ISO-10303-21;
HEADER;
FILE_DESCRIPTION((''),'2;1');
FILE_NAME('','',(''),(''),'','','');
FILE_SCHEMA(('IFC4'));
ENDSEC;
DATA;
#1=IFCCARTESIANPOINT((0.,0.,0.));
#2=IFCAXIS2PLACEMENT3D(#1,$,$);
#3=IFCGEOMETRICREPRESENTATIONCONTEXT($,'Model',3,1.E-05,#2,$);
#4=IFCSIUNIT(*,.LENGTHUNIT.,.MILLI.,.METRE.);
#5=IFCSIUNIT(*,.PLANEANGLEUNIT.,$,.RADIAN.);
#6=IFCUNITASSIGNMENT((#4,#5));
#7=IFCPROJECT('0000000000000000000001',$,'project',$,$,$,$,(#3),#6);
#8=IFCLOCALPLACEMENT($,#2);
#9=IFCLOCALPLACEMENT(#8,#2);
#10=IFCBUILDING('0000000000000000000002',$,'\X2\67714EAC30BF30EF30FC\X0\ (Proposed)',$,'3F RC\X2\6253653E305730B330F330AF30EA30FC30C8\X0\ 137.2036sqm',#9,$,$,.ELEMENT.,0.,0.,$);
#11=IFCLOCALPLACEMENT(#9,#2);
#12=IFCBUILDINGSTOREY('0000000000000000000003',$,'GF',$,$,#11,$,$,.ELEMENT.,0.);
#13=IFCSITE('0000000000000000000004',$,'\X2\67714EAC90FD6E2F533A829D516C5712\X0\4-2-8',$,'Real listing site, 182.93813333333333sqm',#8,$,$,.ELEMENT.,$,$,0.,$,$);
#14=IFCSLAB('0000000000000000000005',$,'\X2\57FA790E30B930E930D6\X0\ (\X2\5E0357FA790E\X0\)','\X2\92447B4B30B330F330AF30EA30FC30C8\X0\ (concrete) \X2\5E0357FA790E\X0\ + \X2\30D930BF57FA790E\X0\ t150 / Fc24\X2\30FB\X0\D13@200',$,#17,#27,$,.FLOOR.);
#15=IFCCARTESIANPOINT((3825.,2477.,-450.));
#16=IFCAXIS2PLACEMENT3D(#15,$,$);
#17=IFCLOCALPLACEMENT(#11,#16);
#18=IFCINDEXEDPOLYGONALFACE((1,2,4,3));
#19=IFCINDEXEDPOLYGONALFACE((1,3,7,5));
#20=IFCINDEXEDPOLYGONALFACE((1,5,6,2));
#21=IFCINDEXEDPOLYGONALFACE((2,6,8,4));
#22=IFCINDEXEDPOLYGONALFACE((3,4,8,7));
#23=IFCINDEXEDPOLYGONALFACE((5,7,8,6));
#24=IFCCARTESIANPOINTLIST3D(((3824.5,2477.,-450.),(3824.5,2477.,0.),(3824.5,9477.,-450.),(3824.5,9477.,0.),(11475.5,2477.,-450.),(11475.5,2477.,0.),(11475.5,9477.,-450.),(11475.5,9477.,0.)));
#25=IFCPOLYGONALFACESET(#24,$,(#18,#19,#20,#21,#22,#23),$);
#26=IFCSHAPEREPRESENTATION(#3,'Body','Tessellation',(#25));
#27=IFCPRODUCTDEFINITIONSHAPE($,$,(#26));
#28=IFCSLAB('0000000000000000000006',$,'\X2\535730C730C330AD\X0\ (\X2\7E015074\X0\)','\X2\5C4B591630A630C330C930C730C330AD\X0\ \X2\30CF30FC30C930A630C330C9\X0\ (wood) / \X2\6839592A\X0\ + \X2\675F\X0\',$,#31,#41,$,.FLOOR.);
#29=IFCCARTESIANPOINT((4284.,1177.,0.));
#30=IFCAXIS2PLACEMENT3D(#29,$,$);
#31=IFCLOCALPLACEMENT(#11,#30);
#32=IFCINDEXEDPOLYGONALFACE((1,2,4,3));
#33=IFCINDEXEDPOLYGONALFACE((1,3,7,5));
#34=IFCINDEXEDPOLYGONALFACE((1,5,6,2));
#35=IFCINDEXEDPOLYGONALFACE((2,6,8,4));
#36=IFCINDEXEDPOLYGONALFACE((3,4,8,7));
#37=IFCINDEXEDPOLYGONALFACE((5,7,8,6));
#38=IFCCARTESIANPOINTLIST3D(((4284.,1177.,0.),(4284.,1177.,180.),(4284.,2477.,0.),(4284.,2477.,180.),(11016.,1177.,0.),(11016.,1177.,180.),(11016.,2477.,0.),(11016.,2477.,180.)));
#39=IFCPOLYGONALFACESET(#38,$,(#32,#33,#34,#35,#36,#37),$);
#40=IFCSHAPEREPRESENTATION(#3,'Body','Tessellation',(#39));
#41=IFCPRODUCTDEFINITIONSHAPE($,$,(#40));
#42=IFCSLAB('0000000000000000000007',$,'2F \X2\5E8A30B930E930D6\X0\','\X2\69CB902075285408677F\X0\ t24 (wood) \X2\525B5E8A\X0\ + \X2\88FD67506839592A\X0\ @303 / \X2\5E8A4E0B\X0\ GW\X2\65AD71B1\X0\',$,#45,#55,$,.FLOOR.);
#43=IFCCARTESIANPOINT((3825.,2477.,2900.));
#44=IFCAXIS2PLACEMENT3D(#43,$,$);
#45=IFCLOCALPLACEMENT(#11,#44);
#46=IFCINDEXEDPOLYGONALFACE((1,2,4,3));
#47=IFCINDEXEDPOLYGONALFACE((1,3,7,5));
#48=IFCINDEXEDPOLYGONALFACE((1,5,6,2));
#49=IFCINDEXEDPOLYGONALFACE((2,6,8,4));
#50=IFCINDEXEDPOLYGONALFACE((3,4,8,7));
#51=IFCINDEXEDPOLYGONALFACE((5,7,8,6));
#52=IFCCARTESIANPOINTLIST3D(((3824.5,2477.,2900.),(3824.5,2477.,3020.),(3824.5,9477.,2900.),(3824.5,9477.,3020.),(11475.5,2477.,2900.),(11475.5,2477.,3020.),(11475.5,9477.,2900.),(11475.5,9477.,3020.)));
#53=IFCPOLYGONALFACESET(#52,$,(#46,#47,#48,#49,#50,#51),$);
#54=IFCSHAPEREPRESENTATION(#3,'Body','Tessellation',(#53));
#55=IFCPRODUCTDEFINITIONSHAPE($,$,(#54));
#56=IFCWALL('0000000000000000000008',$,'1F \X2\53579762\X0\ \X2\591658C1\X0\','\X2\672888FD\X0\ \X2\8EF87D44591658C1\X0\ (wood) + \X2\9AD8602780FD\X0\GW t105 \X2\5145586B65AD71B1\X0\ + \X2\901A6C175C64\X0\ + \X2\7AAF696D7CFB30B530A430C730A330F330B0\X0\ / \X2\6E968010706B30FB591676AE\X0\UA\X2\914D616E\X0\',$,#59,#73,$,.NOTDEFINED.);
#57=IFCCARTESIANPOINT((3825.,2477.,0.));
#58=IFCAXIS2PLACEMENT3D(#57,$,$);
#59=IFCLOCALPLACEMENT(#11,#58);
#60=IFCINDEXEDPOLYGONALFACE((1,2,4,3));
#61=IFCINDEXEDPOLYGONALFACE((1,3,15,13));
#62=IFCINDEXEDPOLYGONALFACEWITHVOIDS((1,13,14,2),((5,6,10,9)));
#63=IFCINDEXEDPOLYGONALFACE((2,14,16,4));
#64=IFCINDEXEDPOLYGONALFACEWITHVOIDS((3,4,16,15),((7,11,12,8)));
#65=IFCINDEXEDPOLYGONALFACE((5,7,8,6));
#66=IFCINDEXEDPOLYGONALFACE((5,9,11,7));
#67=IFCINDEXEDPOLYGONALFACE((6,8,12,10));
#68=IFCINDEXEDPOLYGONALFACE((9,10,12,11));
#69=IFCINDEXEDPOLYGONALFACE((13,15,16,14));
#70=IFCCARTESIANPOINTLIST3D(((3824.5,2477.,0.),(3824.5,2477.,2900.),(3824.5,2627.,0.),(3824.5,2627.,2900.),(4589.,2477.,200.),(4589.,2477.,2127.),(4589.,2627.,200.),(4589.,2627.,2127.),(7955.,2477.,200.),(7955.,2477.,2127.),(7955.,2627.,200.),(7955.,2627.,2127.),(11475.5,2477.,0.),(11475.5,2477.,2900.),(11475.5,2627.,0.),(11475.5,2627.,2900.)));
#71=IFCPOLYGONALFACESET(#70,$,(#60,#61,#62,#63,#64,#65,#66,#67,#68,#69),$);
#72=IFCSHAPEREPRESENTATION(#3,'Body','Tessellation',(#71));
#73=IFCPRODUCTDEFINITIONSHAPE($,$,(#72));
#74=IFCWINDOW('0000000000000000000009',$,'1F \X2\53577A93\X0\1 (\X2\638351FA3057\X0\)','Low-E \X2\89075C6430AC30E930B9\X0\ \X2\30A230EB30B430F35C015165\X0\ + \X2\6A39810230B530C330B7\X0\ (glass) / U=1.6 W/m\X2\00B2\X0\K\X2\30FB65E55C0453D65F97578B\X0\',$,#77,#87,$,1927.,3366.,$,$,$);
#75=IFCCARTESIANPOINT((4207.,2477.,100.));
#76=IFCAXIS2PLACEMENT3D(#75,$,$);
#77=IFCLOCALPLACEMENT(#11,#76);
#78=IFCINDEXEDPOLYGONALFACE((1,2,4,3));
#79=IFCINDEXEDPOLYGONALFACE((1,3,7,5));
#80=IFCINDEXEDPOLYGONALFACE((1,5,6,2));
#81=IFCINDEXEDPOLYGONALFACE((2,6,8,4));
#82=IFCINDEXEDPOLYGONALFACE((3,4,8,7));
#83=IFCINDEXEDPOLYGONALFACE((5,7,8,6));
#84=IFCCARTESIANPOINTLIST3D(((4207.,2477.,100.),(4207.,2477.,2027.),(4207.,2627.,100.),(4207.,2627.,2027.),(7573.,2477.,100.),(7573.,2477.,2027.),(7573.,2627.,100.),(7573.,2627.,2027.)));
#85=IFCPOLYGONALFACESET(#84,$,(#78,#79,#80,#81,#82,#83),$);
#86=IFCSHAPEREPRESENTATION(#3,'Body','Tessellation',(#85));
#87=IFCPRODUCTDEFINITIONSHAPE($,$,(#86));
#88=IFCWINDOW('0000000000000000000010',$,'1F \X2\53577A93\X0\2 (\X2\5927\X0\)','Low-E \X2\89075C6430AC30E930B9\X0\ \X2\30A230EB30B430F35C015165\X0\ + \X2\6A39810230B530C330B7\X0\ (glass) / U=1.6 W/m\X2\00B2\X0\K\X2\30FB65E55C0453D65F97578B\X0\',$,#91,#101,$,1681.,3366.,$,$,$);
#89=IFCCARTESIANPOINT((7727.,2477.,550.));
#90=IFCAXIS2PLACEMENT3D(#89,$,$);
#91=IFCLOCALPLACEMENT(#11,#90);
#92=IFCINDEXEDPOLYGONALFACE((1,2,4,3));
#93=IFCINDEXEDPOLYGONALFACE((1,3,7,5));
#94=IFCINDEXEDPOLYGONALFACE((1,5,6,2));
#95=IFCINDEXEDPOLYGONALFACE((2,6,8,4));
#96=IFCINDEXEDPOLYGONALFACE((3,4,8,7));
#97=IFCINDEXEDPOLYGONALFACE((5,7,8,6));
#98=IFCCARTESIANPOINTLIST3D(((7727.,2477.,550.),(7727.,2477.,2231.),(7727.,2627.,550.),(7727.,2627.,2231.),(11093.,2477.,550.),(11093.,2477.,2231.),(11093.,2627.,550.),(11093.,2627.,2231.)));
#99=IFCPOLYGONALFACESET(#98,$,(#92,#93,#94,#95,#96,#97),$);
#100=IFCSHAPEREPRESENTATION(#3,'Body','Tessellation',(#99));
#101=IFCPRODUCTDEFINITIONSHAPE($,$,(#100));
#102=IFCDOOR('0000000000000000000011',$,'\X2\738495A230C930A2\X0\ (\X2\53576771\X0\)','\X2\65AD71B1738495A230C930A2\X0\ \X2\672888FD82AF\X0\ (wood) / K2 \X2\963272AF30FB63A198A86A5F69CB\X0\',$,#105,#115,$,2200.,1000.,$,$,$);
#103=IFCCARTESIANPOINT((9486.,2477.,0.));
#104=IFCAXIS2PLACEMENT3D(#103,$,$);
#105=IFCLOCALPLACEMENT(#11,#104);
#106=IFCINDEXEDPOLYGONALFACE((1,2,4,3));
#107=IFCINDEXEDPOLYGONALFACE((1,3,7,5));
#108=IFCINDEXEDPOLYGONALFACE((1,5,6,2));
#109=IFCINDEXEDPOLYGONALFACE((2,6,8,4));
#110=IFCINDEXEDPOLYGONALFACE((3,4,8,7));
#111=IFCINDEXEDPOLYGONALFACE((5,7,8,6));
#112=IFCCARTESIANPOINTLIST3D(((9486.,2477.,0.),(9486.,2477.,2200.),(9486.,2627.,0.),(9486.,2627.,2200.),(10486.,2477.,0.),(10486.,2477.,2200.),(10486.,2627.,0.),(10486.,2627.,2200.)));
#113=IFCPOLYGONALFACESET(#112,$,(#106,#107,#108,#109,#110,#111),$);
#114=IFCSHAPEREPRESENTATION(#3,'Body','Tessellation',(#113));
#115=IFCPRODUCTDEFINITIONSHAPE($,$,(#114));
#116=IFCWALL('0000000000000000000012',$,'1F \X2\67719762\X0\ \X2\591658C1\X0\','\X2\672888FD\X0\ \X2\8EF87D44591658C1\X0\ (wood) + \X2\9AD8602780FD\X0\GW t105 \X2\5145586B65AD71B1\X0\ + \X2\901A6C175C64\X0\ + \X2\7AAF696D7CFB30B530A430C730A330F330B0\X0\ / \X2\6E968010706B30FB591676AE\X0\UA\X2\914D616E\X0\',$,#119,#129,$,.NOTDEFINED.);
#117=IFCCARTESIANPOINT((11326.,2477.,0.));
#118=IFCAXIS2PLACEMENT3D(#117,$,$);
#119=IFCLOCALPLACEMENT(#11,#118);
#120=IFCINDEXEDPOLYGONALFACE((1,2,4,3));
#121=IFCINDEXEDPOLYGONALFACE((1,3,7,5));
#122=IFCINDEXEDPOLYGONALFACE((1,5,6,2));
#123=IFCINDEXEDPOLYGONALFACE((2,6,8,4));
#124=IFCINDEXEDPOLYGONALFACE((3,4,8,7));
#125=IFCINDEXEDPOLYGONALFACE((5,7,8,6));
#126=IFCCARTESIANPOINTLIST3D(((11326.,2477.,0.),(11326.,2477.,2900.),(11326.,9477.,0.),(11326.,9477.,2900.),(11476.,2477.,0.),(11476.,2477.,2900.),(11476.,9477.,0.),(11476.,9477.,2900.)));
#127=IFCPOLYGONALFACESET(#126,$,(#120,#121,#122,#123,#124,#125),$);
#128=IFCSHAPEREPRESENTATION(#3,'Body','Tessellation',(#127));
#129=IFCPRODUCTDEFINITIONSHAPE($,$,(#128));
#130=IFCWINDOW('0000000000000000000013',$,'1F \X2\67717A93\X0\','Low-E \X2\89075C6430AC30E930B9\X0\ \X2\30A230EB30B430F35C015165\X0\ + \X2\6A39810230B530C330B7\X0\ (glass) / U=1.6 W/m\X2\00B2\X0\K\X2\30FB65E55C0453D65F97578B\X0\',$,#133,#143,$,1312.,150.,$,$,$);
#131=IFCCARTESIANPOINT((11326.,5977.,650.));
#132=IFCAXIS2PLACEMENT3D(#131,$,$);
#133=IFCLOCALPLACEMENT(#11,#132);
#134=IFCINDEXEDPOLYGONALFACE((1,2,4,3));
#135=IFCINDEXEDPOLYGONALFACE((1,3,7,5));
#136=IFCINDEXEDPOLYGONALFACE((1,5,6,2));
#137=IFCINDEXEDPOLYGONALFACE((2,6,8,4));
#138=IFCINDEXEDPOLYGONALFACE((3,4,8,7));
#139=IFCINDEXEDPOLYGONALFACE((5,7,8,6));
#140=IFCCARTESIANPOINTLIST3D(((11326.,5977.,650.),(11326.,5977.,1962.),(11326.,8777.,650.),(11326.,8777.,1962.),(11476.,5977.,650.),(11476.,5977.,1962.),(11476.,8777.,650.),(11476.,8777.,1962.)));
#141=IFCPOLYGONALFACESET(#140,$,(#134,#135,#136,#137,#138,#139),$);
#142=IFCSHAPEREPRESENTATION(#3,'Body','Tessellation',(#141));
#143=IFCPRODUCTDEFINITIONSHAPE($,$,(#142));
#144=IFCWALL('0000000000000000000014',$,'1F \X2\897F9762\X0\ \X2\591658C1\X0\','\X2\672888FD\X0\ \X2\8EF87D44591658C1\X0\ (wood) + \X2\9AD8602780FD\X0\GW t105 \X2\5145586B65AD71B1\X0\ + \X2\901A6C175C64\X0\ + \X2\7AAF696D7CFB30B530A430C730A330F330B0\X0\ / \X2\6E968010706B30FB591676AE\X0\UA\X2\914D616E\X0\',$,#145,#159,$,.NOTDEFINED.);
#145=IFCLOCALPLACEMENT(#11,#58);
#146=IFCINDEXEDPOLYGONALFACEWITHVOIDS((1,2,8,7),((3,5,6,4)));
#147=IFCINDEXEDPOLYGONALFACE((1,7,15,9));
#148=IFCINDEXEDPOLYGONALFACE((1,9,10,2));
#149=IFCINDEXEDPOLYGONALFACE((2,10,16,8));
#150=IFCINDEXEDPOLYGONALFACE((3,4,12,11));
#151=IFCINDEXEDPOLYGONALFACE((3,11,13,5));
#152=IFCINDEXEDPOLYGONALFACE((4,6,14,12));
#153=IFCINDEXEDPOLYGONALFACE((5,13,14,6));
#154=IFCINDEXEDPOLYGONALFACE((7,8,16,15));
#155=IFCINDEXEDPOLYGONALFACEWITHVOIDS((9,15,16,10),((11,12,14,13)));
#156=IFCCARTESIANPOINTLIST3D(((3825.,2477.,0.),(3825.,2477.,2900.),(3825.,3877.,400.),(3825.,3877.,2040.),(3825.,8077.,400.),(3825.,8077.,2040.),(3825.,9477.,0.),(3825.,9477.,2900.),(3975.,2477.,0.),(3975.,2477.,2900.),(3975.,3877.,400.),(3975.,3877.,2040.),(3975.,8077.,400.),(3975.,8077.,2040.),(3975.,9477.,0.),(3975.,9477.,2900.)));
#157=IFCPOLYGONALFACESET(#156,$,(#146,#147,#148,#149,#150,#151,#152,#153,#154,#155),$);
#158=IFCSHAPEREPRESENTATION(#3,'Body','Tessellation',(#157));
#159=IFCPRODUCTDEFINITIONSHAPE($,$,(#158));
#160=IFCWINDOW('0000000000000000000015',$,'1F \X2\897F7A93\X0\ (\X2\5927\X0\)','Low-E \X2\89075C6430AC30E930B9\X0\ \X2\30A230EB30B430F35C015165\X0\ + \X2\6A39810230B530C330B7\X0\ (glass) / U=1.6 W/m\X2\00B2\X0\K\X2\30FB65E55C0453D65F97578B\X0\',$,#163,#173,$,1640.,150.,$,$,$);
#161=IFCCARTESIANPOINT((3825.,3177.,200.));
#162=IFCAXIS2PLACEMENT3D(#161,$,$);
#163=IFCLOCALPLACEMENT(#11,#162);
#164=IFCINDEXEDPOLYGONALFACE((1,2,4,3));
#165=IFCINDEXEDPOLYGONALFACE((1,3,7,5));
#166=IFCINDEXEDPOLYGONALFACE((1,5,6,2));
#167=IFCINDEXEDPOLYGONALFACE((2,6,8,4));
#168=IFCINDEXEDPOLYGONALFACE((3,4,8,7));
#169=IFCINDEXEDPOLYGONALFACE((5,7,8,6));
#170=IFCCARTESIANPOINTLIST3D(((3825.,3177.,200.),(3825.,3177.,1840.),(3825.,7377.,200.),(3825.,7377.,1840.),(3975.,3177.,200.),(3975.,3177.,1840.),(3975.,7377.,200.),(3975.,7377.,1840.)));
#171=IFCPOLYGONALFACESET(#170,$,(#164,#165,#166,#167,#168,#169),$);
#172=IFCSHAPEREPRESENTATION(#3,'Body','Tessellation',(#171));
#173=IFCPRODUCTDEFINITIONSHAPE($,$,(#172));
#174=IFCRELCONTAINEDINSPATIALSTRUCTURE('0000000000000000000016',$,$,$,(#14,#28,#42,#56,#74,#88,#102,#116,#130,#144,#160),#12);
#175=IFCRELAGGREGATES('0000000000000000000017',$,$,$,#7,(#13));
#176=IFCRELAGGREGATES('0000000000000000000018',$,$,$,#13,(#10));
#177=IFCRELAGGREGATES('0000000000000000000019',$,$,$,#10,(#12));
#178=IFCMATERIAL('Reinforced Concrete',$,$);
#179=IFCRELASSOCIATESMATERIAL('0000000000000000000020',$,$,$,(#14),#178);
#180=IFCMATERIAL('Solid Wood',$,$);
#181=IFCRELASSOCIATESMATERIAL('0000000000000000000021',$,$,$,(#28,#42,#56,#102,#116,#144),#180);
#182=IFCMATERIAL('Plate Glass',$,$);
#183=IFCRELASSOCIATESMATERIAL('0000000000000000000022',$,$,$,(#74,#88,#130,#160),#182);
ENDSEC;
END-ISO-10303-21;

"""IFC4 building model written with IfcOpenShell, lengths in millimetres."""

from ifc_helpers import new_model, si_unit, frame, frame_2d, origin, place, context, project, spatial, rectangle, extrude, material, element, fill, save


model = new_model("IFC4")

# Units and contexts
model_context = context("Model", 3, precision=1e-05, world=origin())
ifc_project = project(units=[si_unit("LENGTHUNIT", "METRE", prefix="MILLI"), si_unit("PLANEANGLEUNIT", "RADIAN")], contexts=[model_context])

# Site, building, storey
site_placement = place(None, origin())
site = spatial("IfcSite", under=ifc_project, at=site_placement, Name="東京都港区芝公園4-2-8", ObjectType="Real listing site, 182.93813333333333sqm", CompositionType="ELEMENT", RefElevation=0.0)
building_placement = place(site_placement, origin())
building = spatial("IfcBuilding", under=site, at=building_placement, Name="東京タワー (Proposed)", ObjectType="3F RC打放しコンクリート 137.2036sqm", CompositionType="ELEMENT", ElevationOfRefHeight=0.0, ElevationOfTerrain=0.0)
storey_placement = place(building_placement, origin())
storey = spatial("IfcBuildingStorey", under=building, at=storey_placement, Name="GF", CompositionType="ELEMENT", Elevation=0.0)

# Slabs
ifc_material_1 = material(Name="Reinforced Concrete")
slab_1_placement = place(storey_placement, frame((3825.0, 2477.0, -450.0)))
element("IfcSlab", 1, at=slab_1_placement, inside=storey, material=ifc_material_1, Name="基礎スラブ (布基礎)", Description="鉄筋コンクリート (concrete) 布基礎 + ベタ基礎 t150 / Fc24・D13@200", PredefinedType="FLOOR", context=model_context, shape_type="SweptSolid", body=[
    extrude(rectangle(XDim=7651.0, YDim=7000.0, at=frame_2d((3825.0, 3500.0))), frame((3825.0, 2477.0, -450.0)), (0.0, 0.0, 1.0), 450.0),
])
ifc_material_2 = material(Name="Solid Wood")
slab_2_placement = place(storey_placement, frame((4284.0, 1177.0, 0.0)))
element("IfcSlab", 2, at=slab_2_placement, inside=storey, material=ifc_material_2, Name="南デッキ (縁側)", Description="屋外ウッドデッキ ハードウッド (wood) / 根太 + 束", PredefinedType="FLOOR", context=model_context, shape_type="SweptSolid", body=[
    extrude(rectangle(XDim=6732.0, YDim=1300.0, at=frame_2d((3366.0, 650.0))), frame((4284.0, 1177.0, 0.0)), (0.0, 0.0, 1.0), 180.0),
])
slab_3_placement = place(storey_placement, frame((3825.0, 2477.0, 2900.0)))
element("IfcSlab", 3, at=slab_3_placement, inside=storey, material=ifc_material_2, Name="2F 床スラブ", Description="構造用合板 t24 (wood) 剛床 + 製材根太 @303 / 床下 GW断熱", PredefinedType="FLOOR", context=model_context, shape_type="SweptSolid", body=[
    extrude(rectangle(XDim=7651.0, YDim=7000.0, at=frame_2d((3825.0, 3500.0))), frame((3825.0, 2477.0, 2900.0)), (0.0, 0.0, 1.0), 120.0),
])

# Wall, openings, windows, door
wall_1_placement = place(storey_placement, frame((3825.0, 2477.0, 0.0)))
wall_1 = element("IfcWall", 4, at=wall_1_placement, inside=storey, material=ifc_material_2, Name="1F 南面 外壁", Description="木製 軸組外壁 (wood) + 高性能GW t105 充填断熱 + 通気層 + 窯業系サイディング / 準耐火・外皮UA配慮", PredefinedType="NOTDEFINED", context=model_context, shape_type="SweptSolid", body=[
    extrude(rectangle(XDim=7651.0, YDim=150.0, at=frame_2d((3825.0, 75.0))), frame((3825.0, 2477.0, 0.0)), (0.0, 0.0, 1.0), 2900.0),
])
opening_1_placement = place(storey_placement, frame((4207.0, 2477.0, 100.0)))
opening_1 = element("IfcOpeningElement", 5, at=opening_1_placement, cuts=wall_1, PredefinedType="NOTDEFINED", context=model_context, shape_type="SweptSolid", body=[
    extrude(rectangle(XDim=3366.0, YDim=150.0, at=frame_2d((1683.0, 75.0))), frame((4207.0, 2477.0, 100.0)), (0.0, 0.0, 1.0), 1927.0),
])
opening_2_placement = place(storey_placement, frame((7727.0, 2477.0, 550.0)))
opening_2 = element("IfcOpeningElement", 6, at=opening_2_placement, cuts=wall_1, PredefinedType="NOTDEFINED", context=model_context, shape_type="SweptSolid", body=[
    extrude(rectangle(XDim=3366.0, YDim=150.0, at=frame_2d((1683.0, 75.0))), frame((7727.0, 2477.0, 550.0)), (0.0, 0.0, 1.0), 1681.0),
])
opening_3_placement = place(storey_placement, frame((9486.0, 2477.0, 0.0)))
opening_3 = element("IfcOpeningElement", 7, at=opening_3_placement, cuts=wall_1, PredefinedType="NOTDEFINED", context=model_context, shape_type="SweptSolid", body=[
    extrude(rectangle(XDim=1000.0, YDim=150.0, at=frame_2d((500.0, 75.0))), frame((9486.0, 2477.0, 0.0)), (0.0, 0.0, 1.0), 2200.0),
])
ifc_material_3 = material(Name="Plate Glass")
window_1_placement = place(storey_placement, frame((4207.0, 2477.0, 100.0)))
window_1 = element("IfcWindow", 8, at=window_1_placement, inside=storey, material=ifc_material_3, Name="1F 南窓1 (掃出し)", Description="Low-E 複層ガラス アルゴン封入 + 樹脂サッシ (glass) / U=1.6 W/m²K・日射取得型", OverallHeight=1927.0, OverallWidth=3366.0, context=model_context, shape_type="SweptSolid", body=[
    extrude(rectangle(XDim=3366.0, YDim=150.0, at=frame_2d((1683.0, 75.0))), frame((4207.0, 2477.0, 100.0)), (0.0, 0.0, 1.0), 1927.0),
])
fill(opening_1, window_1)
window_2_placement = place(storey_placement, frame((7727.0, 2477.0, 550.0)))
window_2 = element("IfcWindow", 9, at=window_2_placement, inside=storey, material=ifc_material_3, Name="1F 南窓2 (大)", Description="Low-E 複層ガラス アルゴン封入 + 樹脂サッシ (glass) / U=1.6 W/m²K・日射取得型", OverallHeight=1681.0, OverallWidth=3366.0, context=model_context, shape_type="SweptSolid", body=[
    extrude(rectangle(XDim=3366.0, YDim=150.0, at=frame_2d((1683.0, 75.0))), frame((7727.0, 2477.0, 550.0)), (0.0, 0.0, 1.0), 1681.0),
])
fill(opening_2, window_2)
door_placement = place(storey_placement, frame((9486.0, 2477.0, 0.0)))
door = element("IfcDoor", 10, at=door_placement, inside=storey, material=ifc_material_2, Name="玄関ドア (南東)", Description="断熱玄関ドア 木製芯 (wood) / K2 防犯・採風機構", OverallHeight=2200.0, OverallWidth=1000.0, context=model_context, shape_type="SweptSolid", body=[
    extrude(rectangle(XDim=1000.0, YDim=150.0, at=frame_2d((500.0, 75.0))), frame((9486.0, 2477.0, 0.0)), (0.0, 0.0, 1.0), 2200.0),
])
fill(opening_3, door)

# Walls, openings, windows
wall_2_placement = place(storey_placement, frame((11326.0, 2477.0, 0.0)))
wall_2 = element("IfcWall", 11, at=wall_2_placement, inside=storey, material=ifc_material_2, Name="1F 東面 外壁", Description="木製 軸組外壁 (wood) + 高性能GW t105 充填断熱 + 通気層 + 窯業系サイディング / 準耐火・外皮UA配慮", PredefinedType="NOTDEFINED", context=model_context, shape_type="SweptSolid", body=[
    extrude(rectangle(XDim=150.0, YDim=7000.0, at=frame_2d((75.0, 3500.0))), frame((11326.0, 2477.0, 0.0)), (0.0, 0.0, 1.0), 2900.0),
])
opening_4_placement = place(storey_placement, frame((11326.0, 5977.0, 650.0)))
opening_4 = element("IfcOpeningElement", 12, at=opening_4_placement, cuts=wall_2, PredefinedType="NOTDEFINED", context=model_context, shape_type="SweptSolid", body=[
    extrude(rectangle(XDim=150.0, YDim=2800.0, at=frame_2d((75.0, 1400.0))), frame((11326.0, 5977.0, 650.0)), (0.0, 0.0, 1.0), 1312.0),
])
window_3_placement = place(storey_placement, frame((11326.0, 5977.0, 650.0)))
window_3 = element("IfcWindow", 13, at=window_3_placement, inside=storey, material=ifc_material_3, Name="1F 東窓", Description="Low-E 複層ガラス アルゴン封入 + 樹脂サッシ (glass) / U=1.6 W/m²K・日射取得型", OverallHeight=1312.0, OverallWidth=150.0, context=model_context, shape_type="SweptSolid", body=[
    extrude(rectangle(XDim=150.0, YDim=2800.0, at=frame_2d((75.0, 1400.0))), frame((11326.0, 5977.0, 650.0)), (0.0, 0.0, 1.0), 1312.0),
])
fill(opening_4, window_3)
wall_3_placement = place(storey_placement, frame((3825.0, 2477.0, 0.0)))
wall_3 = element("IfcWall", 14, at=wall_3_placement, inside=storey, material=ifc_material_2, Name="1F 西面 外壁", Description="木製 軸組外壁 (wood) + 高性能GW t105 充填断熱 + 通気層 + 窯業系サイディング / 準耐火・外皮UA配慮", PredefinedType="NOTDEFINED", context=model_context, shape_type="SweptSolid", body=[
    extrude(rectangle(XDim=150.0, YDim=7000.0, at=frame_2d((75.0, 3500.0))), frame((3825.0, 2477.0, 0.0)), (0.0, 0.0, 1.0), 2900.0),
])
opening_5_placement = place(storey_placement, frame((3825.0, 3177.0, 200.0)))
opening_5 = element("IfcOpeningElement", 15, at=opening_5_placement, cuts=wall_3, PredefinedType="NOTDEFINED", context=model_context, shape_type="SweptSolid", body=[
    extrude(rectangle(XDim=150.0, YDim=4200.0, at=frame_2d((75.0, 2100.0))), frame((3825.0, 3177.0, 200.0)), (0.0, 0.0, 1.0), 1640.0),
])
window_4_placement = place(storey_placement, frame((3825.0, 3177.0, 200.0)))
window_4 = element("IfcWindow", 16, at=window_4_placement, inside=storey, material=ifc_material_3, Name="1F 西窓 (大)", Description="Low-E 複層ガラス アルゴン封入 + 樹脂サッシ (glass) / U=1.6 W/m²K・日射取得型", OverallHeight=1640.0, OverallWidth=150.0, context=model_context, shape_type="SweptSolid", body=[
    extrude(rectangle(XDim=150.0, YDim=4200.0, at=frame_2d((75.0, 2100.0))), frame((3825.0, 3177.0, 200.0)), (0.0, 0.0, 1.0), 1640.0),
])
fill(opening_5, window_4)

save(model, "model.ifc")
